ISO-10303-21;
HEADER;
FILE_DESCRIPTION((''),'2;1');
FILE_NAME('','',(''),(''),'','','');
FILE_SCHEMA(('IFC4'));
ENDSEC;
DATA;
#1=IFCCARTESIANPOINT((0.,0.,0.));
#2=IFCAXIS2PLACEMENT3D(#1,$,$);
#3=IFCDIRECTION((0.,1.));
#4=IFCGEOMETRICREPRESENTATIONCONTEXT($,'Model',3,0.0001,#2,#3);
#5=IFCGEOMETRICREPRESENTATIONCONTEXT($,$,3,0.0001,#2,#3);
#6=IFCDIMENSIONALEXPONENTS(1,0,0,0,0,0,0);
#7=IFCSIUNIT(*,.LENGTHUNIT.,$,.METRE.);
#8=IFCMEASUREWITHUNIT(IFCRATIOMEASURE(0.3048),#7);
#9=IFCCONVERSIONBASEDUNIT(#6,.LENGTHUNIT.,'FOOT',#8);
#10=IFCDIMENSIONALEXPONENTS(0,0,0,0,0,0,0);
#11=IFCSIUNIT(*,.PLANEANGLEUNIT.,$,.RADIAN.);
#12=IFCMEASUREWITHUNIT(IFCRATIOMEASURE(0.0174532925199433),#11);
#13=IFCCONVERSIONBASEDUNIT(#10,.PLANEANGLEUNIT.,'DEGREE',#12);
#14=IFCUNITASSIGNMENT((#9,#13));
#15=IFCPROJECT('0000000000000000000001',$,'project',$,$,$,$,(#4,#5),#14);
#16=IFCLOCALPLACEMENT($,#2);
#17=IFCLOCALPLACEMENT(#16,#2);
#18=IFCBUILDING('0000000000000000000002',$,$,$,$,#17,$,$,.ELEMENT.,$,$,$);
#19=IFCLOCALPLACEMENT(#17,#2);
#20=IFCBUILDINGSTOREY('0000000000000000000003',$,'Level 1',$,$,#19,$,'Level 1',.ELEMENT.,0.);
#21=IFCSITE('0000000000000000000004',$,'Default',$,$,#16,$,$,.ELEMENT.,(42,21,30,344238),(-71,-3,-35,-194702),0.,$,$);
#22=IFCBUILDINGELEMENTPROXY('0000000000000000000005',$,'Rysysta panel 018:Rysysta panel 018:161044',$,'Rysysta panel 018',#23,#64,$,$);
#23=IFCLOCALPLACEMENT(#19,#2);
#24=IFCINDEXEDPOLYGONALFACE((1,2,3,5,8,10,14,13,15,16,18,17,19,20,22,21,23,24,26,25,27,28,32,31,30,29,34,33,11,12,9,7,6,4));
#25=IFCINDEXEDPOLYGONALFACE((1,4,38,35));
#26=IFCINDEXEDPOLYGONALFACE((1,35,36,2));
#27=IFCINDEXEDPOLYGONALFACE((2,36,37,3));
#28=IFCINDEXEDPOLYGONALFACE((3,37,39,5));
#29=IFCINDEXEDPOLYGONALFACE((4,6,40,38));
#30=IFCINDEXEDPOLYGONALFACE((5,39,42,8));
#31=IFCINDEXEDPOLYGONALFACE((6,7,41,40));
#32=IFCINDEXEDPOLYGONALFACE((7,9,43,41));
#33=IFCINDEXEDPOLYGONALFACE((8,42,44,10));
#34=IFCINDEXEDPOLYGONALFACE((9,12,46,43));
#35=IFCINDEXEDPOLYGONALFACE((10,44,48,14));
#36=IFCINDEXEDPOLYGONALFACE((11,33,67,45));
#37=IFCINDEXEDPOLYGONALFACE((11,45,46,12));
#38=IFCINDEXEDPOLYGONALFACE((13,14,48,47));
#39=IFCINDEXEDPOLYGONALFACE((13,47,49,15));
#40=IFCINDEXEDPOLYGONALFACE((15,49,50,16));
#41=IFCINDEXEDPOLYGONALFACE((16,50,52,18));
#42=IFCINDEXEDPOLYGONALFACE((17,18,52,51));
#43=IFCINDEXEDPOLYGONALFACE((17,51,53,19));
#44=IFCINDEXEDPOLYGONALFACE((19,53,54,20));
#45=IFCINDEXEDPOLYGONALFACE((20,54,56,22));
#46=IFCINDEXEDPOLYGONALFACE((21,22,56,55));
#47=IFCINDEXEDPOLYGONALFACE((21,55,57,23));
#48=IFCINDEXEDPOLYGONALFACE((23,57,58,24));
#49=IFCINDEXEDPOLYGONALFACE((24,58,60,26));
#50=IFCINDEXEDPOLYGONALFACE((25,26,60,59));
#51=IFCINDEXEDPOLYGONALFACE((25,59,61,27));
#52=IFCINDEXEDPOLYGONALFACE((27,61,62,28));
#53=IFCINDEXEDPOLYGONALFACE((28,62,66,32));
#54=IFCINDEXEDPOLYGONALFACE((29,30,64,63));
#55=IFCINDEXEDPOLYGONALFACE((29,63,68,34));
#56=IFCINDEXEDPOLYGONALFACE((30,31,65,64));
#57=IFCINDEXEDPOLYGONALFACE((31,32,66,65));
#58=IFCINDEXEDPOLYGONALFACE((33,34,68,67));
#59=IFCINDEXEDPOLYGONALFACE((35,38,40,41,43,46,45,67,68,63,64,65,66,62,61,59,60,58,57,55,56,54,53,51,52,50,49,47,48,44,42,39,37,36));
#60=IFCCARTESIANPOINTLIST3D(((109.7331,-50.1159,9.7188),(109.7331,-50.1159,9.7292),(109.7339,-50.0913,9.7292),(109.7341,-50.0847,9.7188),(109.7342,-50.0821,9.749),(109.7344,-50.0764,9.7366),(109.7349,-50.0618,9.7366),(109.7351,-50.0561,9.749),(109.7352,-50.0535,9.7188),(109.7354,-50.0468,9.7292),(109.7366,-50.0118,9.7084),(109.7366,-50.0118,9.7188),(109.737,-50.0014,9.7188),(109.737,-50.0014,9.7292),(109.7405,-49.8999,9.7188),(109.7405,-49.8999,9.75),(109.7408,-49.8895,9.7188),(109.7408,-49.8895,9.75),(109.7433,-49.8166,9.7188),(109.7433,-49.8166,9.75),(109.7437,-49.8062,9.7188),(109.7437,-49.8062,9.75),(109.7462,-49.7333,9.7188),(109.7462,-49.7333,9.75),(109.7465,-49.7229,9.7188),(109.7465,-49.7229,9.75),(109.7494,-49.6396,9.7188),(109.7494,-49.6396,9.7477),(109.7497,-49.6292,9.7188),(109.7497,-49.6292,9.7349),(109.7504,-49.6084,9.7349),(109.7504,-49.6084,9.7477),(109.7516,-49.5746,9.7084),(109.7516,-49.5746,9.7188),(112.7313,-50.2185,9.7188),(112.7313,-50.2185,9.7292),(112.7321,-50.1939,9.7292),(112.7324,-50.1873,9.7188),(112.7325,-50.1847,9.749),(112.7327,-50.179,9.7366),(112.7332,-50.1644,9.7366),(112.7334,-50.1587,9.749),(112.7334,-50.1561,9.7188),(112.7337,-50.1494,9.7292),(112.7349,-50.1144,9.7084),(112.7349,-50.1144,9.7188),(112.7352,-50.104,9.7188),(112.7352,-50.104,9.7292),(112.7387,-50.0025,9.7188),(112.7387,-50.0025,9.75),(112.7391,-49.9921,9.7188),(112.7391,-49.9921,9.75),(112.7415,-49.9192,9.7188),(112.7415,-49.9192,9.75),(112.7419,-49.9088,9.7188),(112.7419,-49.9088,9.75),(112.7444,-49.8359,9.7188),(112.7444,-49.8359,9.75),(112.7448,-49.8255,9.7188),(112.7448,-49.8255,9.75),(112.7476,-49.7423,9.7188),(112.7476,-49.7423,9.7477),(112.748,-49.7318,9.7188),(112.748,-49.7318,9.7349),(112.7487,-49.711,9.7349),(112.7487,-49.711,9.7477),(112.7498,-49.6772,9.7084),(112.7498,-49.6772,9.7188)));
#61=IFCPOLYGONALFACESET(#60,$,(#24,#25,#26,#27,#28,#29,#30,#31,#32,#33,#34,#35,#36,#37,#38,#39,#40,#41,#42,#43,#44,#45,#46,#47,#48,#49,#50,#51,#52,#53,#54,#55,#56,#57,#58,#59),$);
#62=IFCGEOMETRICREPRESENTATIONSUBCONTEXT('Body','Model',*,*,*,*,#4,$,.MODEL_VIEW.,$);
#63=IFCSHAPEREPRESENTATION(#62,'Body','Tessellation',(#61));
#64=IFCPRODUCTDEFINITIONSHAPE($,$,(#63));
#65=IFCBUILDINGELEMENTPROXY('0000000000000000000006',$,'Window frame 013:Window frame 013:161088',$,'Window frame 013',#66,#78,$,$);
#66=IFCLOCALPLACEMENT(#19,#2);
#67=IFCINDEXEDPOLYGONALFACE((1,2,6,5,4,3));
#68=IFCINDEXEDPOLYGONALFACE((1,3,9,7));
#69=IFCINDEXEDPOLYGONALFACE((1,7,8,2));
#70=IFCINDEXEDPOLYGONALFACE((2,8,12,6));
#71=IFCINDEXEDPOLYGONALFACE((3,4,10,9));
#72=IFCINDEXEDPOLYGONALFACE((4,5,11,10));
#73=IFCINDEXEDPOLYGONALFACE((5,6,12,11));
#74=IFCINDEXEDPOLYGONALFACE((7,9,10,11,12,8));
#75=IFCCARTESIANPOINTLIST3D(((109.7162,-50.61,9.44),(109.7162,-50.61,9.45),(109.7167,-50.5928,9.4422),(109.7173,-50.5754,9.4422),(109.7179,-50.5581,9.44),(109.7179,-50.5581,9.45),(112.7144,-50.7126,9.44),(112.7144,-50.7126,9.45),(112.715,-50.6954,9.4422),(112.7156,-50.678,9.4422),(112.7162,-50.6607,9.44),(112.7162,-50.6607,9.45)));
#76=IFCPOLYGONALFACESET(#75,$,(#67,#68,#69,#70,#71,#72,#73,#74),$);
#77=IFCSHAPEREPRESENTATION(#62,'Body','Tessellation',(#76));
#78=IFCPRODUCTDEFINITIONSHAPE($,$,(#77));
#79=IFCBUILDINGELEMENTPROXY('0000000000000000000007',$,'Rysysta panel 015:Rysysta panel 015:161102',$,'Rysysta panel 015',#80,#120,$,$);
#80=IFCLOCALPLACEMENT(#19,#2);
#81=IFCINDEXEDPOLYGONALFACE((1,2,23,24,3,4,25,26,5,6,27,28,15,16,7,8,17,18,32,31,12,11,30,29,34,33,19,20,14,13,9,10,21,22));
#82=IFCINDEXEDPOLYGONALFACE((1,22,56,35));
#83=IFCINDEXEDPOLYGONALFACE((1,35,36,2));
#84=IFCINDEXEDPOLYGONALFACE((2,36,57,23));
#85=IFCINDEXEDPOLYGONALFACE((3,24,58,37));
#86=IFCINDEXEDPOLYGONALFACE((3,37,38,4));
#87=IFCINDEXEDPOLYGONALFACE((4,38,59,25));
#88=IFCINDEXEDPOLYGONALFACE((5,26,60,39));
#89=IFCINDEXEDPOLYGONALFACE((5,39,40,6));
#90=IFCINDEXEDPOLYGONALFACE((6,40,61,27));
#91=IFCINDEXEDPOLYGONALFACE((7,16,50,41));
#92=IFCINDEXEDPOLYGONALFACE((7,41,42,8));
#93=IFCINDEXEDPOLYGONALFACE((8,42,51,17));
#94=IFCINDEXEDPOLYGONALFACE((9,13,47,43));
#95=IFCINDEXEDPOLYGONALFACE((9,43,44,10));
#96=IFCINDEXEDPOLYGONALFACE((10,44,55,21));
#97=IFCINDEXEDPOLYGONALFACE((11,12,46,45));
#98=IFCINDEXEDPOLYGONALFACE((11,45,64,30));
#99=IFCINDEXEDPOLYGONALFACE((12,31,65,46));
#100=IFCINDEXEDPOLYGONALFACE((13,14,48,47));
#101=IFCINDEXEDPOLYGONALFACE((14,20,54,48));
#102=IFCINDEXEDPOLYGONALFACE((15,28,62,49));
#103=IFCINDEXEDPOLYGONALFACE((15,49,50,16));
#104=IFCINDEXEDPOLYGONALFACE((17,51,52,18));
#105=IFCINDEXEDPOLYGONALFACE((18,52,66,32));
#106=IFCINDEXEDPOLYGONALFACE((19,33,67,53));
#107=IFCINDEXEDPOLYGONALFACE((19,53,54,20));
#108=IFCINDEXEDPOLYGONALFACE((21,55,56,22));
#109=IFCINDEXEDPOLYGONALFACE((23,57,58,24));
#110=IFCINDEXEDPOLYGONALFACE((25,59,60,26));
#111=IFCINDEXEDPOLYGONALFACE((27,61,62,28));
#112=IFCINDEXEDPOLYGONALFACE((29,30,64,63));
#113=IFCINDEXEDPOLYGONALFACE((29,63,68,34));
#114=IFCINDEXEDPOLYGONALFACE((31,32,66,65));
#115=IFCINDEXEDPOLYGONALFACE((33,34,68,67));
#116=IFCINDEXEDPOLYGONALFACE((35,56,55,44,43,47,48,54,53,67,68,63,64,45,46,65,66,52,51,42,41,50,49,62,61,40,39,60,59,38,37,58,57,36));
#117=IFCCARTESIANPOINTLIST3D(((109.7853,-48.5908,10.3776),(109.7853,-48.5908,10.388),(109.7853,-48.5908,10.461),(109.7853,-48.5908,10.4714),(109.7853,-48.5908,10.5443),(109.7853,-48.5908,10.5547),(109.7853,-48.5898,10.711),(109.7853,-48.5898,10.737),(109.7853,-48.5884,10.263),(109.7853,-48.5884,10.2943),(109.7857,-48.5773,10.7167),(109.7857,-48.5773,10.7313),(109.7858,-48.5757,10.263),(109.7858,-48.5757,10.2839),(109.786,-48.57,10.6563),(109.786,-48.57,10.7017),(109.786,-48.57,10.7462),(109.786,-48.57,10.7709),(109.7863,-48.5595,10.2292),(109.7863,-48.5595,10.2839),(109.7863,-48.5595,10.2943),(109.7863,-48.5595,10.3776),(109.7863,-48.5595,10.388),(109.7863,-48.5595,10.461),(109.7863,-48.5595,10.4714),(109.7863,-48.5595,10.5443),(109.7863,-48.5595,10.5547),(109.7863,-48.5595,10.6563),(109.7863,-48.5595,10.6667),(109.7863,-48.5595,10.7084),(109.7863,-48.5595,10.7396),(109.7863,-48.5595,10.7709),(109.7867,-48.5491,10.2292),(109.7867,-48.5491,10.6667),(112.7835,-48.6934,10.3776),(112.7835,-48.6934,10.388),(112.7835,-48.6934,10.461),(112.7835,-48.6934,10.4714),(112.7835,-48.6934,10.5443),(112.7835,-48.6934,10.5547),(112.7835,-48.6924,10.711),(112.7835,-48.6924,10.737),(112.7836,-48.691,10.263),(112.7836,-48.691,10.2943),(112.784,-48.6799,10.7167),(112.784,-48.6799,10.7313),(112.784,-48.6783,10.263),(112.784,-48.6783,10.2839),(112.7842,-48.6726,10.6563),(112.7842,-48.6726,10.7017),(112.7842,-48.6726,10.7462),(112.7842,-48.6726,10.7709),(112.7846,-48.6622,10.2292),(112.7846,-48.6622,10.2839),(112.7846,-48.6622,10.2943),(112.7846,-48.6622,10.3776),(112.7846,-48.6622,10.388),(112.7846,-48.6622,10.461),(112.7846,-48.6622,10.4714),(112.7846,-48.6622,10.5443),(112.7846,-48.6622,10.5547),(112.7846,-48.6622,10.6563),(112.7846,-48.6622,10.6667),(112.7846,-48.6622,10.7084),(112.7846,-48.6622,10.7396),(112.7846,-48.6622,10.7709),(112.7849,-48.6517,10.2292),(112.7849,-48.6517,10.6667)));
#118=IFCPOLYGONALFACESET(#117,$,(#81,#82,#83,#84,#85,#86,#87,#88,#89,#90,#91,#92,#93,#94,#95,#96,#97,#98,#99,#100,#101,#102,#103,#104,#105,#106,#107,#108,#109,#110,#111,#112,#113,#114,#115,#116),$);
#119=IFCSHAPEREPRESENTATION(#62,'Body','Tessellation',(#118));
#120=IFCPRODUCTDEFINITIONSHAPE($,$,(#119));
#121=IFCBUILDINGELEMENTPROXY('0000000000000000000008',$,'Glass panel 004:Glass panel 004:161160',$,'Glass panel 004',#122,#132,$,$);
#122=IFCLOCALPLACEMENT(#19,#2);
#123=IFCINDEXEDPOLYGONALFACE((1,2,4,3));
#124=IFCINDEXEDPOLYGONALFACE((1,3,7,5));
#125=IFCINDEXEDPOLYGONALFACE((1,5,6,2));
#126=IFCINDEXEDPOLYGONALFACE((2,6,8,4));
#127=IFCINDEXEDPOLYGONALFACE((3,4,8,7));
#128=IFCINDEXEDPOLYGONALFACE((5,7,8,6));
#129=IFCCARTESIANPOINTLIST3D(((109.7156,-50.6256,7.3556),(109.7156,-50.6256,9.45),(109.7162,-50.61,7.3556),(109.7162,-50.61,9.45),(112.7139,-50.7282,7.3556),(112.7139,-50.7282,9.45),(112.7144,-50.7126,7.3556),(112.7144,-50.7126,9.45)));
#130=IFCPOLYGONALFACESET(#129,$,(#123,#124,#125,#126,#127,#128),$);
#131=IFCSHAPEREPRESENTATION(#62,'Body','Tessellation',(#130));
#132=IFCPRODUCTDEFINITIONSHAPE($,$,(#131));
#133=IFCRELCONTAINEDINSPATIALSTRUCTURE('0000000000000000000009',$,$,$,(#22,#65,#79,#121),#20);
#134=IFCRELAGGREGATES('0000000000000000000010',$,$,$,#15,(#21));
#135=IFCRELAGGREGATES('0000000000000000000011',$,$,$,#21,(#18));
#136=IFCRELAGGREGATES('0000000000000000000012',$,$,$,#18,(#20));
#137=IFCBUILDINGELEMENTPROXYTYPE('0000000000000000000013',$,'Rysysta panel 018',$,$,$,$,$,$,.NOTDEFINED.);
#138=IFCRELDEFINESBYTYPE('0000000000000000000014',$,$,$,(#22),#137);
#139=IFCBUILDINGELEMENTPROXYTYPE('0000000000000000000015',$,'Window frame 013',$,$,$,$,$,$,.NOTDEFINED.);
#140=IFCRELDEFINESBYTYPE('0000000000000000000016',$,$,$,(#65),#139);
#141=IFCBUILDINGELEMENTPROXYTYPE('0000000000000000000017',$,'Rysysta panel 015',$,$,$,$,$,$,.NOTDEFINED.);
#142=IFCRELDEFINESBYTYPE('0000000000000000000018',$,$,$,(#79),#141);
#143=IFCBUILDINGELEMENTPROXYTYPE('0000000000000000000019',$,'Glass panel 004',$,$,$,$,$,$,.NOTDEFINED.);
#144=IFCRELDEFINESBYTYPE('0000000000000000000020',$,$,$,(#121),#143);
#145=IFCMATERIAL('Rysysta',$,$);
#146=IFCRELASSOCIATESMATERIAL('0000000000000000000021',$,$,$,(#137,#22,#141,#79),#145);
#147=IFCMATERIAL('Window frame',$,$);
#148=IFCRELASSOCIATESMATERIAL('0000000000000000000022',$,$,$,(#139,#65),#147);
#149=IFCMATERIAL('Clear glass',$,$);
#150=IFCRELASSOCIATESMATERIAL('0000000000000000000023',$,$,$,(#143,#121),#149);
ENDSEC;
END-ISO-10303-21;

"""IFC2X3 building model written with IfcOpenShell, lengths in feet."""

from ifc_helpers import new_model, entity, si_unit, converted_unit, direction, frame, frame_2d, origin, origin_2d_with_axis, place, context, subcontext, project, spatial, polyline, circle_curve, parameter, trimmed, segment, composite_curve, rectangle, outline, extrude, source, transform, mapped, material, type_object, type_shapes, element, save


model = new_model("IFC2X3")

# Units and contexts
model_context = context("Model", 3, precision=0.0001, world=origin(), true_north=direction((0.0, 1.0)))
context_of_model = context(None, 3, precision=0.0001, world=origin(), true_north=direction((0.0, 1.0)))
body_context = subcontext(model_context, "Body", "Model", "MODEL_VIEW")
ifc_project = project(units=[converted_unit("LENGTHUNIT", "FOOT", entity("IfcRatioMeasure", 0.3048), si_unit("LENGTHUNIT", "METRE"), dimensions=[1, 0, 0, 0, 0, 0, 0]), converted_unit("PLANEANGLEUNIT", "DEGREE", entity("IfcRatioMeasure", 0.0174532925199433), si_unit("PLANEANGLEUNIT", "RADIAN"), dimensions=[0, 0, 0, 0, 0, 0, 0])], contexts=[model_context, context_of_model])

# Site, building, storey
site_placement = place(None, origin())
site = spatial("IfcSite", under=ifc_project, at=site_placement, Name="Default", CompositionType="ELEMENT", RefLatitude=(42, 21, 30, 344238), RefLongitude=(-71, -3, -35, -194702), RefElevation=0.0)
building_placement = place(site_placement, origin())
building = spatial("IfcBuilding", under=site, at=building_placement, CompositionType="ELEMENT")
storey_placement = place(building_placement, origin())
storey = spatial("IfcBuildingStorey", under=building, at=storey_placement, Name="Level 1", LongName="Level 1", CompositionType="ELEMENT", Elevation=0.0)

# Building element proxies
ifc_material_1 = material(Name="Rysysta")
building_element_proxy_type_1 = type_object("IfcBuildingElementProxyType", Name="Rysysta panel 018", PredefinedType="NOTDEFINED", material=ifc_material_1)
shared_shape_1 = source(origin(), body_context, "Body", "SweptSolid", [
    extrude(outline(polyline([(-0.2918, -0.0116), (-0.2918, -0.022), (0.1457, -0.022), (0.1457, -0.0116), (0.1873, -0.0116), (0.1956, 0.0062), (0.2103, 0.0062), (0.2186, -0.0116), (0.2498, -0.0116), (0.2498, -0.0012), (0.2252, -0.0012), (0.216, 0.0186), (0.1899, 0.0186), (0.1807, -0.0012), (0.1353, -0.0012), (0.1353, -0.0116), (0.0337, -0.0116), (0.0337, 0.0196), (0.0233, 0.0196), (0.0233, -0.0116), (-0.0496, -0.0116), (-0.0496, 0.0196), (-0.06, 0.0196), (-0.06, -0.0116), (-0.133, -0.0116), (-0.133, 0.0196), (-0.1434, 0.0196), (-0.1434, -0.0116), (-0.2267, -0.0116), (-0.2267, 0.0173), (-0.258, 0.0173), (-0.258, 0.0045), (-0.2371, 0.0045), (-0.2371, -0.0116), (-0.2918, -0.0116)])), frame((109.7416, -49.8662, 9.7304), z_axis=(-0.999415, 0.034202, 0.0), x_axis=(-0.034202, -0.999415, 0.0)), (0.0, 0.0, -1.0), 3.0),
])
type_shapes(building_element_proxy_type_1, [shared_shape_1])
proxy_1_placement = place(storey_placement, origin())
element("IfcBuildingElementProxy", 1, at=proxy_1_placement, inside=storey, type_object=building_element_proxy_type_1, material=ifc_material_1, Name="Rysysta panel 018:Rysysta panel 018:161044", ObjectType="Rysysta panel 018", context=body_context, shape_type="MappedRepresentation", body=[
    mapped(shared_shape_1, transform((0.0, 0.0, 0.0), scale=1.0)),
])
ifc_material_2 = material(Name="Window frame")
building_element_proxy_type_2 = type_object("IfcBuildingElementProxyType", Name="Window frame 013", PredefinedType="NOTDEFINED", material=ifc_material_2)
shared_shape_2 = source(origin(), body_context, "Body", "SweptSolid", [
    extrude(outline(composite_curve([segment(polyline([(-0.005, -0.026), (0.005, -0.026)]), True, "CONTINUOUS"), segment(polyline([(0.005, -0.026), (0.005, 0.026)]), True, "CONTINUOUS"), segment(polyline([(0.005, 0.026), (-0.005, 0.026)]), True, "CONTINUOUS"), segment(trimmed(circle_curve(frame_2d((-0.1385, 0.0), x_axis=(0.0, 1.0)), 0.136), [parameter(258.997827)], [parameter(281.002173)], True, "PARAMETER"), False, "CONTINUOUS")], self_intersect=False)), frame((109.717, -50.5841, 9.445), z_axis=(0.999415, -0.034202, 0.0), x_axis=(0.0, 0.0, 1.0)), (0.0, 0.0, 1.0), 3.0),
])
type_shapes(building_element_proxy_type_2, [shared_shape_2])
proxy_2_placement = place(storey_placement, origin())
element("IfcBuildingElementProxy", 2, at=proxy_2_placement, inside=storey, type_object=building_element_proxy_type_2, material=ifc_material_2, Name="Window frame 013:Window frame 013:161088", ObjectType="Window frame 013", context=body_context, shape_type="MappedRepresentation", body=[
    mapped(shared_shape_2, transform((0.0, 0.0, 0.0), scale=1.0)),
])
building_element_proxy_type_3 = type_object("IfcBuildingElementProxyType", Name="Rysysta panel 015", PredefinedType="NOTDEFINED", material=ifc_material_1)
shared_shape_3 = source(origin(), body_context, "Body", "SweptSolid", [
    extrude(outline(polyline([(-0.022, 0.1457), (-0.022, -0.2918), (-0.0116, -0.2918), (-0.0116, -0.2371), (0.0045, -0.2371), (0.0045, -0.258), (0.0173, -0.258), (0.0173, -0.2267), (-0.0116, -0.2267), (-0.0116, -0.1434), (0.0196, -0.1434), (0.0196, -0.133), (-0.0116, -0.133), (-0.0116, -0.06), (0.0196, -0.06), (0.0196, -0.0496), (-0.0116, -0.0496), (-0.0116, 0.0233), (0.0196, 0.0233), (0.0196, 0.0337), (-0.0116, 0.0337), (-0.0116, 0.1353), (-0.0012, 0.1353), (-0.0012, 0.1807), (0.0186, 0.1899), (0.0186, 0.216), (-0.0012, 0.2252), (-0.0012, 0.2498), (-0.0116, 0.2498), (-0.0116, 0.2186), (0.0062, 0.2103), (0.0062, 0.1956), (-0.0116, 0.1873), (-0.0116, 0.1457), (-0.022, 0.1457)])), frame((109.7859, -48.5711, 10.521), z_axis=(-0.999415, 0.034202, 0.0), x_axis=(-0.034202, -0.999415, 0.0)), (0.0, 0.0, -1.0), 3.0),
])
type_shapes(building_element_proxy_type_3, [shared_shape_3])
proxy_3_placement = place(storey_placement, origin())
element("IfcBuildingElementProxy", 3, at=proxy_3_placement, inside=storey, type_object=building_element_proxy_type_3, material=ifc_material_1, Name="Rysysta panel 015:Rysysta panel 015:161102", ObjectType="Rysysta panel 015", context=body_context, shape_type="MappedRepresentation", body=[
    mapped(shared_shape_3, transform((0.0, 0.0, 0.0), scale=1.0)),
])
ifc_material_3 = material(Name="Clear glass")
building_element_proxy_type_4 = type_object("IfcBuildingElementProxyType", Name="Glass panel 004", PredefinedType="NOTDEFINED", material=ifc_material_3)
shared_shape_4 = source(origin(), body_context, "Body", "SweptSolid", [
    extrude(rectangle(XDim=3.0, YDim=0.0156, at=origin_2d_with_axis()), frame((111.215, -50.6691, 7.3556), z_axis=(0.0, 0.0, 1.0), x_axis=(-0.999415, 0.034202, 0.0)), (0.0, 0.0, 1.0), 2.0943),
])
type_shapes(building_element_proxy_type_4, [shared_shape_4])
proxy_4_placement = place(storey_placement, origin())
element("IfcBuildingElementProxy", 4, at=proxy_4_placement, inside=storey, type_object=building_element_proxy_type_4, material=ifc_material_3, Name="Glass panel 004:Glass panel 004:161160", ObjectType="Glass panel 004", context=body_context, shape_type="MappedRepresentation", body=[
    mapped(shared_shape_4, transform((0.0, 0.0, 0.0), scale=1.0)),
])

save(model, "model.ifc")
